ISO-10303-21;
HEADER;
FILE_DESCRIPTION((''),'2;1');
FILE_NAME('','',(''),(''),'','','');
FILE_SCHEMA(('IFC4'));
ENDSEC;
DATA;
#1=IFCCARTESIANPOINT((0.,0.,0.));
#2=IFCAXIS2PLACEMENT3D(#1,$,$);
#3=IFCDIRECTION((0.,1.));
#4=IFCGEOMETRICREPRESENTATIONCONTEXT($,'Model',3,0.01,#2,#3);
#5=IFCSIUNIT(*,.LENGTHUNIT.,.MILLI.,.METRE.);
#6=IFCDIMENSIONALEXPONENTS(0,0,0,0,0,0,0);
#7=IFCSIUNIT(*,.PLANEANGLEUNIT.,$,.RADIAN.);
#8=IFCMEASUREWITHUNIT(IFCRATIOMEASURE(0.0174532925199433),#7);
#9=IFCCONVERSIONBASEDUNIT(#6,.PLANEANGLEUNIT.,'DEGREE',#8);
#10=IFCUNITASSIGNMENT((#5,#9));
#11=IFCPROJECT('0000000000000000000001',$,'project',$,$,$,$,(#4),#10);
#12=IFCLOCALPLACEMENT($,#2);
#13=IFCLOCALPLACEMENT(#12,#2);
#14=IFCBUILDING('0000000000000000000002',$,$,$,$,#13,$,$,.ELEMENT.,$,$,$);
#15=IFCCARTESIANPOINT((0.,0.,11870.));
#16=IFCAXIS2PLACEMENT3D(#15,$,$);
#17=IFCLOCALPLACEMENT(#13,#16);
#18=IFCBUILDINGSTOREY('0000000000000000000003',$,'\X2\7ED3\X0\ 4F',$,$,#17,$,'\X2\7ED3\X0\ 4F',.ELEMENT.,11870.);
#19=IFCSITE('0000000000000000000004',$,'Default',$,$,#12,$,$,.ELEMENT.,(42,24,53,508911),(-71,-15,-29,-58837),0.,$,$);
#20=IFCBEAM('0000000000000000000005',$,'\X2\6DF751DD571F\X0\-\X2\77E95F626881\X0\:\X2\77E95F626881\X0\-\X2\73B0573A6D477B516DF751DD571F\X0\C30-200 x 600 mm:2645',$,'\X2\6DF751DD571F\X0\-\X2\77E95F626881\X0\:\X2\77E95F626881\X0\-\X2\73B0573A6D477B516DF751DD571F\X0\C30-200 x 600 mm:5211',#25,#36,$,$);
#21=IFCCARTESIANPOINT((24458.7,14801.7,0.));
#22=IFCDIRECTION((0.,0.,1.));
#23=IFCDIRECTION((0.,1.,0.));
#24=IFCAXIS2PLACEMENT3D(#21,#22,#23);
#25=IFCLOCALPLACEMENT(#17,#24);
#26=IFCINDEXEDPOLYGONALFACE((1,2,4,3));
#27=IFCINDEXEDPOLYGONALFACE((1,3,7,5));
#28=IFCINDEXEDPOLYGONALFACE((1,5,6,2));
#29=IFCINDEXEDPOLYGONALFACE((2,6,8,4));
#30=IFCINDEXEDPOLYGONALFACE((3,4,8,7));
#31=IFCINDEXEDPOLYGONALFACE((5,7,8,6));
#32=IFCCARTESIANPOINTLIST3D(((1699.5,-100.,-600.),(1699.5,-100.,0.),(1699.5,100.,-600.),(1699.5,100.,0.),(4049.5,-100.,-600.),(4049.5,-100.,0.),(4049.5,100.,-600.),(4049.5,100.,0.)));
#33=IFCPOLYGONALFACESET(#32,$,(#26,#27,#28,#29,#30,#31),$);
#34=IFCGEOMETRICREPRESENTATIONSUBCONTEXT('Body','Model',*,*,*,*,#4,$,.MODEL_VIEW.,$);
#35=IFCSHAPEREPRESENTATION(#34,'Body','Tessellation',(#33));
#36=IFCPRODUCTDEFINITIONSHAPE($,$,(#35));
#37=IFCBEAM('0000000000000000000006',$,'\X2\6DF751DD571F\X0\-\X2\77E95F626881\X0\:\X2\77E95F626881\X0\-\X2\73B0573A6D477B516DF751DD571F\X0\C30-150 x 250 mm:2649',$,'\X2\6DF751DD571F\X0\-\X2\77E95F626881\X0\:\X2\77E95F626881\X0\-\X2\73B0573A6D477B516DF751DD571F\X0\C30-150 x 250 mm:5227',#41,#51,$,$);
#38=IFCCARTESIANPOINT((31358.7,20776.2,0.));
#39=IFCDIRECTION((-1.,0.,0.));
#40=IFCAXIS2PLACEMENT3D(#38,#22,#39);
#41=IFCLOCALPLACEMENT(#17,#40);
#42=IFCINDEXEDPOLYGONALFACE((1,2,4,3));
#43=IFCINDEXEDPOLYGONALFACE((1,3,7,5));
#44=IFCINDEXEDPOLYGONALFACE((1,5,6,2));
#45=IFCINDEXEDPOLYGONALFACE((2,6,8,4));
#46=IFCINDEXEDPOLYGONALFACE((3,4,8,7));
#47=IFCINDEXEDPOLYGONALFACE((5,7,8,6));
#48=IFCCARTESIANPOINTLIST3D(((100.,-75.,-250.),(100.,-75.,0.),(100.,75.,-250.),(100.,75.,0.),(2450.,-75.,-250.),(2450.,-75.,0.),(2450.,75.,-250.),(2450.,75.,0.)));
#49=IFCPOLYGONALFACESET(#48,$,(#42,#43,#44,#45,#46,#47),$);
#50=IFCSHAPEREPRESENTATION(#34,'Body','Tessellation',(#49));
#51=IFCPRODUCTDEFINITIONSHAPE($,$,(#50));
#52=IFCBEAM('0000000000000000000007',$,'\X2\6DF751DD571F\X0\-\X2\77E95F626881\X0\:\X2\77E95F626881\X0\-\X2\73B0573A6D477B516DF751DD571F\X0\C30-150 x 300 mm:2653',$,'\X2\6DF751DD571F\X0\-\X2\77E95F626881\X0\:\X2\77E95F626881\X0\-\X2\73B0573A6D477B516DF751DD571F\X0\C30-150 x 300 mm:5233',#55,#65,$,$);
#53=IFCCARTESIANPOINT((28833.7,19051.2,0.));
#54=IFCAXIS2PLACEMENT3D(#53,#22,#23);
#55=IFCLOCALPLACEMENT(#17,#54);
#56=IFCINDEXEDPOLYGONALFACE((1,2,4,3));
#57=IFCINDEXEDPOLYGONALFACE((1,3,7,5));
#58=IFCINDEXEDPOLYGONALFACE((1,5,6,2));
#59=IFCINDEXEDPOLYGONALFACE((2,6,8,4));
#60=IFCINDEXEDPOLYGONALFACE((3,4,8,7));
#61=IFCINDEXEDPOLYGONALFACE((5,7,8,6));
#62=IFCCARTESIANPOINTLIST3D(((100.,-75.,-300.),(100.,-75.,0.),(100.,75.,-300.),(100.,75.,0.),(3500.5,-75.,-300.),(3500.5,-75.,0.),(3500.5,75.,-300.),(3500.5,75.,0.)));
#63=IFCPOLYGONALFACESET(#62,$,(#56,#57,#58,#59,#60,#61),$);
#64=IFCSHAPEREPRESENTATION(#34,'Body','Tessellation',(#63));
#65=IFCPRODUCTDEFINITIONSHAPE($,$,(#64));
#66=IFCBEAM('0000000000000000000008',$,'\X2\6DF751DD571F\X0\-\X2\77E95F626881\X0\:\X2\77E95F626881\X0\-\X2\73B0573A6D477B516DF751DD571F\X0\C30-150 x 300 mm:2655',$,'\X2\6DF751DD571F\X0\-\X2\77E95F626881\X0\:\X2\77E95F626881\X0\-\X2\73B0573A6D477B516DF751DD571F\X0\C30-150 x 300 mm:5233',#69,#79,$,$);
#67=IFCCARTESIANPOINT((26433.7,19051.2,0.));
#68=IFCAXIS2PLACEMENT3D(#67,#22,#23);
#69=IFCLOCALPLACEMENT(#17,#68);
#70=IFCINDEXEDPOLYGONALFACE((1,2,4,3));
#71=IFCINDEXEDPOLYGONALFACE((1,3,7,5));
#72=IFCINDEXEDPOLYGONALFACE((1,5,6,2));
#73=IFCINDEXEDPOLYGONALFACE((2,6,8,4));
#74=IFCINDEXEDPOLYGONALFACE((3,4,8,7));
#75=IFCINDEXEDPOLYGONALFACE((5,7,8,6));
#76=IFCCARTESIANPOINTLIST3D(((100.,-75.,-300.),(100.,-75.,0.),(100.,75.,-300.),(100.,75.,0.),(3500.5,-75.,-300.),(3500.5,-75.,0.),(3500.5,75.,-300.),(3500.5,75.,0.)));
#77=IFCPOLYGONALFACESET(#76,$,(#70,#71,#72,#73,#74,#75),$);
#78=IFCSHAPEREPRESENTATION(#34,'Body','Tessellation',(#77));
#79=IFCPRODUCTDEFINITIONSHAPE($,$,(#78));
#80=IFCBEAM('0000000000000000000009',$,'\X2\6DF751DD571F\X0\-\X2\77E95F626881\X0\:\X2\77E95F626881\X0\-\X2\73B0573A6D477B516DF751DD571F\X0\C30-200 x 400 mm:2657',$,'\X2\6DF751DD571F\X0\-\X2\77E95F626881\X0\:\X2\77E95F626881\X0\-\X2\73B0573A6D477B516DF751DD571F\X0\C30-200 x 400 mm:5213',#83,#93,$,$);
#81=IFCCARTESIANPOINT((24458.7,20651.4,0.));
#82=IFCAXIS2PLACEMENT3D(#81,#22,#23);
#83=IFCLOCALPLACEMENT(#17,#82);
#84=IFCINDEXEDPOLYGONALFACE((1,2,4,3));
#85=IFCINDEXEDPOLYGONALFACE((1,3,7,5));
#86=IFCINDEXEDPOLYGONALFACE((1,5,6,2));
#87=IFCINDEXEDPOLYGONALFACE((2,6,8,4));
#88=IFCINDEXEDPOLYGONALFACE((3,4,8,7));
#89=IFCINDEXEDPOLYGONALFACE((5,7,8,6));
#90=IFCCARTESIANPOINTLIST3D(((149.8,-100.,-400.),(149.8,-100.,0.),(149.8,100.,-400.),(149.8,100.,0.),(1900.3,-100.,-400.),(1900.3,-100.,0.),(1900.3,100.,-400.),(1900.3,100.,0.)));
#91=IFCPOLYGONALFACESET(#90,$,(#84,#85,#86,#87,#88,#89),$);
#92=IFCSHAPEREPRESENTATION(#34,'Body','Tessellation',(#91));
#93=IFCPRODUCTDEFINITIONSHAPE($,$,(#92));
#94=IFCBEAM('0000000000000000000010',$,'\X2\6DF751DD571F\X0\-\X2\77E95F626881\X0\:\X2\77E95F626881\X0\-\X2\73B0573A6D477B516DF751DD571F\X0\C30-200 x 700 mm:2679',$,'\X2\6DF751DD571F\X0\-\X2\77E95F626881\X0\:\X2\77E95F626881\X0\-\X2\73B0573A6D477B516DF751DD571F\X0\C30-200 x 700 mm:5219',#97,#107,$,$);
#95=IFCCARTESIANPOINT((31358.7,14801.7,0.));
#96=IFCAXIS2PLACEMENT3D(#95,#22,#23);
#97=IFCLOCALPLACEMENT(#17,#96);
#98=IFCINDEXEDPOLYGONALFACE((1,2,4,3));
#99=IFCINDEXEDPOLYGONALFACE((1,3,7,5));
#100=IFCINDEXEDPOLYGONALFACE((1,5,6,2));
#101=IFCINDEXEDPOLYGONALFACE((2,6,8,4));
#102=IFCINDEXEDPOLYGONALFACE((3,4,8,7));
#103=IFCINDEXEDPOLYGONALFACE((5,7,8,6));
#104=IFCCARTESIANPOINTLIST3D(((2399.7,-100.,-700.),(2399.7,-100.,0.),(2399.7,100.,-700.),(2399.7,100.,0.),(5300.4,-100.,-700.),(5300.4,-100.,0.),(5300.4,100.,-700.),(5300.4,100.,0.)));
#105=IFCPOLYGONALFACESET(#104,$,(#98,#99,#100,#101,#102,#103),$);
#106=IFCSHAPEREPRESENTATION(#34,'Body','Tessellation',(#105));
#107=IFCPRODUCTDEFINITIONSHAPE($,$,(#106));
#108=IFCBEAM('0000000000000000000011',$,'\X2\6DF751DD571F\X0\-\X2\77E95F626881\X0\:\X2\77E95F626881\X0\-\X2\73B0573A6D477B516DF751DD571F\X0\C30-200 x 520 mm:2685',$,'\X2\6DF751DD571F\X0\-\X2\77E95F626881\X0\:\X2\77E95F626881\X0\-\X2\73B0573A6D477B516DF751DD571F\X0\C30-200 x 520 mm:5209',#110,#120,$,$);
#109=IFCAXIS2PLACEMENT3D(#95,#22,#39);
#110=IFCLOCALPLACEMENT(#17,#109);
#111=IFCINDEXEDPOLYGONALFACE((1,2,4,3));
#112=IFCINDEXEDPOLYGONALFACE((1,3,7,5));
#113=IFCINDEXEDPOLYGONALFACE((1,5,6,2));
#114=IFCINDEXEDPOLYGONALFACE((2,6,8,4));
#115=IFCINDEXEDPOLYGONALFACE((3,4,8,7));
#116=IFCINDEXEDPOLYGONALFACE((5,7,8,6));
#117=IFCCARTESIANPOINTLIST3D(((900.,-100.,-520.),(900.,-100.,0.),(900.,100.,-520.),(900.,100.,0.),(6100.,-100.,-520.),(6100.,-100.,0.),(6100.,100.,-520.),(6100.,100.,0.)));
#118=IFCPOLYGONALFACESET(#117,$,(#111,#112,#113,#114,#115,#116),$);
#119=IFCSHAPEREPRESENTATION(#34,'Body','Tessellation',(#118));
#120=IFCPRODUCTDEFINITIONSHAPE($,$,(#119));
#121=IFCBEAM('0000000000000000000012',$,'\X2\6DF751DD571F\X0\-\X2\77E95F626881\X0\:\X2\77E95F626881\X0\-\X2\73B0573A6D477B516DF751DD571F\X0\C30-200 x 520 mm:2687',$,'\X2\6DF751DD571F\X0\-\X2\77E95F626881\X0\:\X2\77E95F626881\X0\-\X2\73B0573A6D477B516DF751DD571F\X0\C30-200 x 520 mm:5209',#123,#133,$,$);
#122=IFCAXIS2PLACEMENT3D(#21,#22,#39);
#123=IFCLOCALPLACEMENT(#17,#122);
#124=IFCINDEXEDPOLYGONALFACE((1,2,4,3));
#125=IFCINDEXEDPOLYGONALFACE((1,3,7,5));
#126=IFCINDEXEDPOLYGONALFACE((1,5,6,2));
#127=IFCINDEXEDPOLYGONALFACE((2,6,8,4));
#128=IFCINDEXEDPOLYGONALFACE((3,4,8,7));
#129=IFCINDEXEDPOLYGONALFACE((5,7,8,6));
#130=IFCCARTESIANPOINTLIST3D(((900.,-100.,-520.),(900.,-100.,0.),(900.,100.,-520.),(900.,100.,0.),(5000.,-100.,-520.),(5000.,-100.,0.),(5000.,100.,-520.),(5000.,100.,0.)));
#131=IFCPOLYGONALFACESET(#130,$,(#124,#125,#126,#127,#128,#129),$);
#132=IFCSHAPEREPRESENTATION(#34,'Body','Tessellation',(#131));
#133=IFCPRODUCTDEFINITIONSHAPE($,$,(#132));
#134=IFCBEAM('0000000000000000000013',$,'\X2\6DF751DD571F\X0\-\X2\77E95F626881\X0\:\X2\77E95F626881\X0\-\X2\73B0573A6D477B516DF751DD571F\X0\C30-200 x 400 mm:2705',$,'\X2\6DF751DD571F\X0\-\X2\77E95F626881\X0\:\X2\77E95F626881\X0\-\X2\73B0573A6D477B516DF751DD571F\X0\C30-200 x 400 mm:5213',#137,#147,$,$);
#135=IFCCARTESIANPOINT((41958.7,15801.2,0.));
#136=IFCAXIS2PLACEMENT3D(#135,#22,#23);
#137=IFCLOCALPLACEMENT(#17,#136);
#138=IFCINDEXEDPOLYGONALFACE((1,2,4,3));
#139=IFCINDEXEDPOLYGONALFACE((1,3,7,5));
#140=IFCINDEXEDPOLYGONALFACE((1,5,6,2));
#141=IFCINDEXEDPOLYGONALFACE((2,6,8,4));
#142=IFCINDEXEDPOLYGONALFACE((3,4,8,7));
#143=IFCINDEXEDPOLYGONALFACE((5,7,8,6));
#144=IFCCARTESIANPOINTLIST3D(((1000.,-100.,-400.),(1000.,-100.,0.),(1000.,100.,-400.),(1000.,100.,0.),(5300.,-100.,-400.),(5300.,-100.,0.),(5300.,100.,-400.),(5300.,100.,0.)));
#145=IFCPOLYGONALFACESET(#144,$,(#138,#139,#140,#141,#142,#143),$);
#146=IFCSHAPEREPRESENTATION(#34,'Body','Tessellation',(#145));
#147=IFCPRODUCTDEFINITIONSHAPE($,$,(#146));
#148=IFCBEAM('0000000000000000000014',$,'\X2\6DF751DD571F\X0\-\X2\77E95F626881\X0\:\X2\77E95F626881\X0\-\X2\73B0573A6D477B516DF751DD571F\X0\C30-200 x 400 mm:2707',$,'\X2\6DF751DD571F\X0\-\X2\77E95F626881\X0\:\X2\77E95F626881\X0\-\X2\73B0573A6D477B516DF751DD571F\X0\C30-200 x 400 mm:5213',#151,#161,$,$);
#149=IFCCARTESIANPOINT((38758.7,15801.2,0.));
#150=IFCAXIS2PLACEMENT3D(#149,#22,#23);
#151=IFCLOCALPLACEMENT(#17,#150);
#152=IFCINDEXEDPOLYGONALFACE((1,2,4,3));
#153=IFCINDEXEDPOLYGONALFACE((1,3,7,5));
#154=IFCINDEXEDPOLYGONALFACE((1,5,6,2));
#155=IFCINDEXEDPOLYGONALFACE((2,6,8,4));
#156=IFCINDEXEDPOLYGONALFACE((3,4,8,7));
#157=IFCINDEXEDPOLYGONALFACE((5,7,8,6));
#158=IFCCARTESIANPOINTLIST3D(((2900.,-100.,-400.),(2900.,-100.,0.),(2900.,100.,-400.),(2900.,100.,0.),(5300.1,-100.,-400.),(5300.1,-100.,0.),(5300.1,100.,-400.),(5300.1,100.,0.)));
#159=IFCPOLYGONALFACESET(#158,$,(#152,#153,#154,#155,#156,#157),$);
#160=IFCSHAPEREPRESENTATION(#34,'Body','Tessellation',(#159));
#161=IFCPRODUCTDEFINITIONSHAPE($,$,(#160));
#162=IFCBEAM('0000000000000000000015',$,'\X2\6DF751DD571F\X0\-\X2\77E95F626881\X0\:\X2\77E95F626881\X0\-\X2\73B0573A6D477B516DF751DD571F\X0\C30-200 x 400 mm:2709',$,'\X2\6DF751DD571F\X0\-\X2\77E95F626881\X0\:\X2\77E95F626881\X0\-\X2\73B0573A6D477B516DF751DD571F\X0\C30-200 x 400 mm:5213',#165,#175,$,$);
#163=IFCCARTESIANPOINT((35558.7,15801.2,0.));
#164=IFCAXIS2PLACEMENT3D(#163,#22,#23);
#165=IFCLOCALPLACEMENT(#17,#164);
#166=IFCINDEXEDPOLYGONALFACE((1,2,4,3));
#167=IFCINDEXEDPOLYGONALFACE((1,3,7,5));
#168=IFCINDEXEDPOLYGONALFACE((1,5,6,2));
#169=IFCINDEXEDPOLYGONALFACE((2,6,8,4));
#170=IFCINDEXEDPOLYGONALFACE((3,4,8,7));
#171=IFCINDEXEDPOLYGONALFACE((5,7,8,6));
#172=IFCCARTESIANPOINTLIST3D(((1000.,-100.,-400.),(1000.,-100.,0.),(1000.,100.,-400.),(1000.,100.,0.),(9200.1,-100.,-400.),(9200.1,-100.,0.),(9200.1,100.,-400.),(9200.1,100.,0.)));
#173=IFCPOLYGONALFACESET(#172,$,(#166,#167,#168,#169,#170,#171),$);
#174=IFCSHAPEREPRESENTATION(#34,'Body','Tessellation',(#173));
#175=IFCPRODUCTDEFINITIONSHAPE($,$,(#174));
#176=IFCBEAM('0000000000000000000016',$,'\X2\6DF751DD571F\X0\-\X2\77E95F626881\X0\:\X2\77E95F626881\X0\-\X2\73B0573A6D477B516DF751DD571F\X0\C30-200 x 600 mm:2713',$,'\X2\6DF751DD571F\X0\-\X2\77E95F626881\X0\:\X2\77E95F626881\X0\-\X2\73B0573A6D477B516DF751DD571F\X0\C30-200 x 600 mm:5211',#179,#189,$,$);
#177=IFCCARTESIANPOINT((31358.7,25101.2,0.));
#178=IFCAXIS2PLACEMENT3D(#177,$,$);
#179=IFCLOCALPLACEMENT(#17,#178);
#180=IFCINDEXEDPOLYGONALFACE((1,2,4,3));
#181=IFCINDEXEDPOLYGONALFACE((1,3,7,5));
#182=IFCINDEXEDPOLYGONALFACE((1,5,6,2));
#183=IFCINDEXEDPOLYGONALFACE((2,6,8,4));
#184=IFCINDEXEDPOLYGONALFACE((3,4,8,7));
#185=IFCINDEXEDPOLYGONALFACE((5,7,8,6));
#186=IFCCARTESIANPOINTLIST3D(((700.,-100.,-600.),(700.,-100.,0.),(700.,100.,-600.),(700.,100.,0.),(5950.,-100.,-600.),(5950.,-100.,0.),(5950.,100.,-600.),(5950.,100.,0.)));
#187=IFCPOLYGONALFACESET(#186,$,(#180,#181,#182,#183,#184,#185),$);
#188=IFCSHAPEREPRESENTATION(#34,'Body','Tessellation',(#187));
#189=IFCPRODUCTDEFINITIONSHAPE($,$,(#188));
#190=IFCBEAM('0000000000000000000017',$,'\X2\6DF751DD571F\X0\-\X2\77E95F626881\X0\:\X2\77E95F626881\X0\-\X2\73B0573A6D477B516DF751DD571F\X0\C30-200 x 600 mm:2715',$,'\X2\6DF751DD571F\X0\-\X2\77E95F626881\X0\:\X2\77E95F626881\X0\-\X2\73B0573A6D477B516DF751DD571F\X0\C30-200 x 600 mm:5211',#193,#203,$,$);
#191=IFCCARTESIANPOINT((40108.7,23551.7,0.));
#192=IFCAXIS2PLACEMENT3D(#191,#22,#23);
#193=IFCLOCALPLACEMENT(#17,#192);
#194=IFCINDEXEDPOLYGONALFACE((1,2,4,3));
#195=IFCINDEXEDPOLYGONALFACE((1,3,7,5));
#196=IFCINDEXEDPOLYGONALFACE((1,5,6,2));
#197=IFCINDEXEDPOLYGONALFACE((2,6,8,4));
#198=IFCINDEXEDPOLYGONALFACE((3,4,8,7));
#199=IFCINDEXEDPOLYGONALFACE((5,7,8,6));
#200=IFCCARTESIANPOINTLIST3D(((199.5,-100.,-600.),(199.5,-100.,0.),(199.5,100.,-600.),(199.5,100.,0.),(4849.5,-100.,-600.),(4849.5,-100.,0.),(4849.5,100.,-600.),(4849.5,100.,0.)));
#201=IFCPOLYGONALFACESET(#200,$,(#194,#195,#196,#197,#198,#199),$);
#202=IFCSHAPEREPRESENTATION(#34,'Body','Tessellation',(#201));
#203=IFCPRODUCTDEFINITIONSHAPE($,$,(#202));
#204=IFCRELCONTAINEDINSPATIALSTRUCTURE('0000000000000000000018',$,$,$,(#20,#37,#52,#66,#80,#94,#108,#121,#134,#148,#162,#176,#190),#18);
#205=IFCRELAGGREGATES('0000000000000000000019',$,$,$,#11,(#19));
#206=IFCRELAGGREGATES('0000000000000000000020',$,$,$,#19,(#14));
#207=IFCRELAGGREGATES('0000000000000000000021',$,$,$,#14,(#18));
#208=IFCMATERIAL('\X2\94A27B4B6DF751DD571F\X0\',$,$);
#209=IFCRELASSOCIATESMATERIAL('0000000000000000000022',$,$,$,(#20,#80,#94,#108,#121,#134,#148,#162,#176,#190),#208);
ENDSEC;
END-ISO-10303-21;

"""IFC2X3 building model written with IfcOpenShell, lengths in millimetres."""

from ifc_helpers import new_model, entity, si_unit, converted_unit, direction, frame, frame_2d, origin, origin_2d_with_axis, place, context, subcontext, project, spatial, rectangle, extrude, material, element, save


model = new_model("IFC2X3")

# Units and contexts
model_context = context("Model", 3, precision=0.01, world=origin(), true_north=direction((0.0, 1.0)))
body_context = subcontext(model_context, "Body", "Model", "MODEL_VIEW")
ifc_project = project(units=[si_unit("LENGTHUNIT", "METRE", prefix="MILLI"), converted_unit("PLANEANGLEUNIT", "DEGREE", entity("IfcRatioMeasure", 0.0174532925199433), si_unit("PLANEANGLEUNIT", "RADIAN"), dimensions=[0, 0, 0, 0, 0, 0, 0])], contexts=[model_context])

# Site, building, storey
site_placement = place(None, origin())
site = spatial("IfcSite", under=ifc_project, at=site_placement, Name="Default", CompositionType="ELEMENT", RefLatitude=(42, 24, 53, 508911), RefLongitude=(-71, -15, -29, -58837), RefElevation=0.0)
building_placement = place(site_placement, origin())
building = spatial("IfcBuilding", under=site, at=building_placement, CompositionType="ELEMENT")
storey_placement = place(building_placement, frame((0.0, 0.0, 11870.0)))
storey = spatial("IfcBuildingStorey", under=building, at=storey_placement, Name="结 4F", LongName="结 4F", CompositionType="ELEMENT", Elevation=11870.0)

# Beams
ifc_material = material(Name="钢筋混凝土")
beam_1_placement = place(storey_placement, frame((24458.7, 14801.7, 0.0), z_axis=(0.0, 0.0, 1.0), x_axis=(0.0, 1.0, 0.0)))
element("IfcBeam", 1, at=beam_1_placement, inside=storey, material=ifc_material, Name="混凝土-矩形梁:矩形梁-现场浇筑混凝土C30-200 x 600 mm:2645", ObjectType="混凝土-矩形梁:矩形梁-现场浇筑混凝土C30-200 x 600 mm:5211", context=body_context, shape_type="SweptSolid", body=[
    extrude(rectangle(XDim=600.0, YDim=200.0, at=frame_2d((0.0, 0.0), x_axis=(1.0, 0.0))), frame((1699.5, 0.0, -300.0), z_axis=(1.0, 0.0, 0.0), x_axis=(0.0, 0.0, -1.0)), (0.0, 0.0, 1.0), 2350.0),
])
beam_2_placement = place(storey_placement, frame((31358.7, 20776.2, 0.0), z_axis=(0.0, 0.0, 1.0), x_axis=(-1.0, 0.0, 0.0)))
element("IfcBeam", 2, at=beam_2_placement, inside=storey, Name="混凝土-矩形梁:矩形梁-现场浇筑混凝土C30-150 x 250 mm:2649", ObjectType="混凝土-矩形梁:矩形梁-现场浇筑混凝土C30-150 x 250 mm:5227", context=body_context, shape_type="SweptSolid", body=[
    extrude(rectangle(XDim=250.0, YDim=150.0, at=frame_2d((0.0, 0.0), x_axis=(1.0, 0.0))), frame((100.0, 0.0, -125.0), z_axis=(1.0, 0.0, 0.0), x_axis=(0.0, 0.0, -1.0)), (0.0, 0.0, 1.0), 2350.0),
])
beam_3_placement = place(storey_placement, frame((28833.7, 19051.2, 0.0), z_axis=(0.0, 0.0, 1.0), x_axis=(0.0, 1.0, 0.0)))
element("IfcBeam", 3, at=beam_3_placement, inside=storey, Name="混凝土-矩形梁:矩形梁-现场浇筑混凝土C30-150 x 300 mm:2653", ObjectType="混凝土-矩形梁:矩形梁-现场浇筑混凝土C30-150 x 300 mm:5233", context=body_context, shape_type="SweptSolid", body=[
    extrude(rectangle(XDim=300.0, YDim=150.0, at=frame_2d((0.0, 0.0), x_axis=(1.0, 0.0))), frame((100.0, 0.0, -150.0), z_axis=(1.0, 0.0, 0.0), x_axis=(0.0, 0.0, -1.0)), (0.0, 0.0, 1.0), 3400.5),
])
beam_4_placement = place(storey_placement, frame((26433.7, 19051.2, 0.0), z_axis=(0.0, 0.0, 1.0), x_axis=(0.0, 1.0, 0.0)))
element("IfcBeam", 4, at=beam_4_placement, inside=storey, Name="混凝土-矩形梁:矩形梁-现场浇筑混凝土C30-150 x 300 mm:2655", ObjectType="混凝土-矩形梁:矩形梁-现场浇筑混凝土C30-150 x 300 mm:5233", context=body_context, shape_type="SweptSolid", body=[
    extrude(rectangle(XDim=300.0, YDim=150.0, at=frame_2d((0.0, 0.0), x_axis=(1.0, 0.0))), frame((100.0, 0.0, -150.0), z_axis=(1.0, 0.0, 0.0), x_axis=(0.0, 0.0, -1.0)), (0.0, 0.0, 1.0), 3400.5),
])
beam_5_placement = place(storey_placement, frame((24458.7, 20651.4, 0.0), z_axis=(0.0, 0.0, 1.0), x_axis=(0.0, 1.0, 0.0)))
element("IfcBeam", 5, at=beam_5_placement, inside=storey, material=ifc_material, Name="混凝土-矩形梁:矩形梁-现场浇筑混凝土C30-200 x 400 mm:2657", ObjectType="混凝土-矩形梁:矩形梁-现场浇筑混凝土C30-200 x 400 mm:5213", context=body_context, shape_type="SweptSolid", body=[
    extrude(rectangle(XDim=400.0, YDim=200.0, at=frame_2d((0.0, 0.0), x_axis=(1.0, 0.0))), frame((149.8, 0.0, -200.0), z_axis=(1.0, 0.0, 0.0), x_axis=(0.0, 0.0, -1.0)), (0.0, 0.0, 1.0), 1750.5),
])
beam_6_placement = place(storey_placement, frame((31358.7, 14801.7, 0.0), z_axis=(0.0, 0.0, 1.0), x_axis=(0.0, 1.0, 0.0)))
element("IfcBeam", 6, at=beam_6_placement, inside=storey, material=ifc_material, Name="混凝土-矩形梁:矩形梁-现场浇筑混凝土C30-200 x 700 mm:2679", ObjectType="混凝土-矩形梁:矩形梁-现场浇筑混凝土C30-200 x 700 mm:5219", context=body_context, shape_type="SweptSolid", body=[
    extrude(rectangle(XDim=700.0, YDim=200.0, at=frame_2d((0.0, 0.0), x_axis=(1.0, 0.0))), frame((2399.7, 0.0, -350.0), z_axis=(1.0, 0.0, 0.0), x_axis=(0.0, 0.0, -1.0)), (0.0, 0.0, 1.0), 2900.7),
])
beam_7_placement = place(storey_placement, frame((31358.7, 14801.7, 0.0), z_axis=(0.0, 0.0, 1.0), x_axis=(-1.0, 0.0, 0.0)))
element("IfcBeam", 7, at=beam_7_placement, inside=storey, material=ifc_material, Name="混凝土-矩形梁:矩形梁-现场浇筑混凝土C30-200 x 520 mm:2685", ObjectType="混凝土-矩形梁:矩形梁-现场浇筑混凝土C30-200 x 520 mm:5209", context=body_context, shape_type="SweptSolid", body=[
    extrude(rectangle(XDim=520.0, YDim=200.0, at=frame_2d((0.0, 0.0), x_axis=(1.0, 0.0))), frame((900.0, 0.0, -260.0), z_axis=(1.0, 0.0, 0.0), x_axis=(0.0, 0.0, -1.0)), (0.0, 0.0, 1.0), 5200.0),
])
beam_8_placement = place(storey_placement, frame((24458.7, 14801.7, 0.0), z_axis=(0.0, 0.0, 1.0), x_axis=(-1.0, 0.0, 0.0)))
element("IfcBeam", 8, at=beam_8_placement, inside=storey, material=ifc_material, Name="混凝土-矩形梁:矩形梁-现场浇筑混凝土C30-200 x 520 mm:2687", ObjectType="混凝土-矩形梁:矩形梁-现场浇筑混凝土C30-200 x 520 mm:5209", context=body_context, shape_type="SweptSolid", body=[
    extrude(rectangle(XDim=520.0, YDim=200.0, at=frame_2d((0.0, 0.0), x_axis=(1.0, 0.0))), frame((900.0, 0.0, -260.0), z_axis=(1.0, 0.0, 0.0), x_axis=(0.0, 0.0, -1.0)), (0.0, 0.0, 1.0), 4100.0),
])
beam_9_placement = place(storey_placement, frame((41958.7, 15801.2, 0.0), z_axis=(0.0, 0.0, 1.0), x_axis=(0.0, 1.0, 0.0)))
element("IfcBeam", 9, at=beam_9_placement, inside=storey, material=ifc_material, Name="混凝土-矩形梁:矩形梁-现场浇筑混凝土C30-200 x 400 mm:2705", ObjectType="混凝土-矩形梁:矩形梁-现场浇筑混凝土C30-200 x 400 mm:5213", context=body_context, shape_type="SweptSolid", body=[
    extrude(rectangle(XDim=400.0, YDim=200.0, at=origin_2d_with_axis()), frame((1000.0, 0.0, -200.0), z_axis=(1.0, 0.0, 0.0), x_axis=(0.0, 0.0, -1.0)), (0.0, 0.0, 1.0), 4300.0),
])
beam_10_placement = place(storey_placement, frame((38758.7, 15801.2, 0.0), z_axis=(0.0, 0.0, 1.0), x_axis=(0.0, 1.0, 0.0)))
element("IfcBeam", 10, at=beam_10_placement, inside=storey, material=ifc_material, Name="混凝土-矩形梁:矩形梁-现场浇筑混凝土C30-200 x 400 mm:2707", ObjectType="混凝土-矩形梁:矩形梁-现场浇筑混凝土C30-200 x 400 mm:5213", context=body_context, shape_type="SweptSolid", body=[
    extrude(rectangle(XDim=400.0, YDim=200.0, at=frame_2d((0.0, 0.0), x_axis=(1.0, 0.0))), frame((2900.0, 0.0, -200.0), z_axis=(1.0, 0.0, 0.0), x_axis=(0.0, 0.0, -1.0)), (0.0, 0.0, 1.0), 2400.0),
])
beam_11_placement = place(storey_placement, frame((35558.7, 15801.2, 0.0), z_axis=(0.0, 0.0, 1.0), x_axis=(0.0, 1.0, 0.0)))
element("IfcBeam", 11, at=beam_11_placement, inside=storey, material=ifc_material, Name="混凝土-矩形梁:矩形梁-现场浇筑混凝土C30-200 x 400 mm:2709", ObjectType="混凝土-矩形梁:矩形梁-现场浇筑混凝土C30-200 x 400 mm:5213", context=body_context, shape_type="SweptSolid", body=[
    extrude(rectangle(XDim=400.0, YDim=200.0, at=frame_2d((0.0, 0.0), x_axis=(1.0, 0.0))), frame((1000.0, 0.0, -200.0), z_axis=(1.0, 0.0, 0.0), x_axis=(0.0, 0.0, -1.0)), (0.0, 0.0, 1.0), 8200.0),
])
beam_12_placement = place(storey_placement, frame((31358.7, 25101.2, 0.0)))
element("IfcBeam", 12, at=beam_12_placement, inside=storey, material=ifc_material, Name="混凝土-矩形梁:矩形梁-现场浇筑混凝土C30-200 x 600 mm:2713", ObjectType="混凝土-矩形梁:矩形梁-现场浇筑混凝土C30-200 x 600 mm:5211", context=body_context, shape_type="SweptSolid", body=[
    extrude(rectangle(XDim=600.0, YDim=200.0, at=frame_2d((0.0, 0.0), x_axis=(1.0, 0.0))), frame((700.0, 0.0, -300.0), z_axis=(1.0, 0.0, 0.0), x_axis=(0.0, 0.0, -1.0)), (0.0, 0.0, 1.0), 5250.0),
])
beam_13_placement = place(storey_placement, frame((40108.7, 23551.7, 0.0), z_axis=(0.0, 0.0, 1.0), x_axis=(0.0, 1.0, 0.0)))
element("IfcBeam", 13, at=beam_13_placement, inside=storey, material=ifc_material, Name="混凝土-矩形梁:矩形梁-现场浇筑混凝土C30-200 x 600 mm:2715", ObjectType="混凝土-矩形梁:矩形梁-现场浇筑混凝土C30-200 x 600 mm:5211", context=body_context, shape_type="SweptSolid", body=[
    extrude(rectangle(XDim=600.0, YDim=200.0, at=frame_2d((0.0, 0.0), x_axis=(1.0, 0.0))), frame((199.5, 0.0, -300.0), z_axis=(1.0, 0.0, 0.0), x_axis=(0.0, 0.0, -1.0)), (0.0, 0.0, 1.0), 4650.0),
])

save(model, "model.ifc")
